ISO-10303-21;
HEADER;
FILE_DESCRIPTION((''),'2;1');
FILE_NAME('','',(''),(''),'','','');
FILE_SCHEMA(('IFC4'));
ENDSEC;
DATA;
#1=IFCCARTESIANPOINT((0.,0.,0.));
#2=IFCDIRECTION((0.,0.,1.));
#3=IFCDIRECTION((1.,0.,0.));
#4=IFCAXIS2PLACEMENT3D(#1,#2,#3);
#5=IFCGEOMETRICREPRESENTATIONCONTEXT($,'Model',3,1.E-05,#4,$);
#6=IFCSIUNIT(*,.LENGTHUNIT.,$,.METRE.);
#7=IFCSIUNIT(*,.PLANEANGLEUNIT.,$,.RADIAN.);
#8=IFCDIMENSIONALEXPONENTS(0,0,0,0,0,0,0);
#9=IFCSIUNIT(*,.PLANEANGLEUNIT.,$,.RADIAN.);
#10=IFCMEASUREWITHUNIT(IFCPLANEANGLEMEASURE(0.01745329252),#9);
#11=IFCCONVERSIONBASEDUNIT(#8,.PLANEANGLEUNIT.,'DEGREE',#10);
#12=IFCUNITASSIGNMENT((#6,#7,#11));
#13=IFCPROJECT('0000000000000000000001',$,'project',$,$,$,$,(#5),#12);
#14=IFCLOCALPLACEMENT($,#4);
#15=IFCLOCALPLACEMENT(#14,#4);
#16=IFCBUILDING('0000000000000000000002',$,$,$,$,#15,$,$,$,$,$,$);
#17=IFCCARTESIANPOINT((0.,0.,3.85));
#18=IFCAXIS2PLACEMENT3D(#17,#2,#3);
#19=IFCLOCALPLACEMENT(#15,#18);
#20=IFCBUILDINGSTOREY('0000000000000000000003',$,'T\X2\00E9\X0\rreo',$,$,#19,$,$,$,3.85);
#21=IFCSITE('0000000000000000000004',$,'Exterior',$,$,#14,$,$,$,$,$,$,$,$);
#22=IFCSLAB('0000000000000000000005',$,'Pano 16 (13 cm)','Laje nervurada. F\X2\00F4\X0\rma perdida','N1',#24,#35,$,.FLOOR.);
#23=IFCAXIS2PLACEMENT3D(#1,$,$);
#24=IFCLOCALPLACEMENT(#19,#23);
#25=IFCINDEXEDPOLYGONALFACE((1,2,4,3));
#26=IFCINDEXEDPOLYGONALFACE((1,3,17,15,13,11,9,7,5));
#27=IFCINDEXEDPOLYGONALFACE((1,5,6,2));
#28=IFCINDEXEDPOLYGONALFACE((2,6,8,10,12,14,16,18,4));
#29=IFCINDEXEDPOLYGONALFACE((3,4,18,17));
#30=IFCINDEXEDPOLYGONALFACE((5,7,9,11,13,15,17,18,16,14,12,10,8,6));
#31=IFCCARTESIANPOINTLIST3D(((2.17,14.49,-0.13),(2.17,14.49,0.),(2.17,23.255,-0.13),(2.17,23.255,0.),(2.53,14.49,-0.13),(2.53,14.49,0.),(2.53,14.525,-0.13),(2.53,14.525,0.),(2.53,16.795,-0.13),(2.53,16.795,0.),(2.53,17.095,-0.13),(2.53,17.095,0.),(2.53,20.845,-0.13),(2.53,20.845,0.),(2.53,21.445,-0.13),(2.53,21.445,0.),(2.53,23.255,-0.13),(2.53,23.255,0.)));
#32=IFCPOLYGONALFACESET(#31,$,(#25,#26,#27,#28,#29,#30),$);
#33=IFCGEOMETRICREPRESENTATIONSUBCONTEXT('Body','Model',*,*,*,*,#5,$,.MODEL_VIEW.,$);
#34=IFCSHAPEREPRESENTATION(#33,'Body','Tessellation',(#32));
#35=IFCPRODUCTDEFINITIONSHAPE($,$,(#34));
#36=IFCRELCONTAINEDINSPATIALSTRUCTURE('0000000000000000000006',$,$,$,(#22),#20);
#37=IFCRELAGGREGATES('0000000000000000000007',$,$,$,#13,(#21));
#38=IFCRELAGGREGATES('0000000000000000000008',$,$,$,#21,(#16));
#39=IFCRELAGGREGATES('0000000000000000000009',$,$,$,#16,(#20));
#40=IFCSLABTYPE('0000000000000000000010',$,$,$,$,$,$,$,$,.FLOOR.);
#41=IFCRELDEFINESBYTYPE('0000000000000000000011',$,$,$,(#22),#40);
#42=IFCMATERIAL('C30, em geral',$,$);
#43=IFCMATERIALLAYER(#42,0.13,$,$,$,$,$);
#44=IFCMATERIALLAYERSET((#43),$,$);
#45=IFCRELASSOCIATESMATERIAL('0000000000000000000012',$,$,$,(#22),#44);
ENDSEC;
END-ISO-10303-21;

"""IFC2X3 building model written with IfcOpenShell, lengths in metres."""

from ifc_helpers import new_model, entity, si_unit, converted_unit, frame, origin_with_axes, place, context, subcontext, project, spatial, polyline, outline, extrude, material, layer, layer_set, layer_usage, type_object, element, save


model = new_model("IFC2X3")

# Units and contexts
model_context = context("Model", 3, precision=1e-05, world=origin_with_axes())
body_context = subcontext(model_context, "Body", "Model", "MODEL_VIEW")
ifc_project = project(units=[si_unit("LENGTHUNIT", "METRE"), si_unit("PLANEANGLEUNIT", "RADIAN"), converted_unit("PLANEANGLEUNIT", "DEGREE", entity("IfcPlaneAngleMeasure", 0.01745329252), si_unit("PLANEANGLEUNIT", "RADIAN"), dimensions=[0, 0, 0, 0, 0, 0, 0])], contexts=[model_context])

# Site, building, storey
site_placement = place(None, origin_with_axes())
site = spatial("IfcSite", under=ifc_project, at=site_placement, Name="Exterior")
building_placement = place(site_placement, origin_with_axes())
building = spatial("IfcBuilding", under=site, at=building_placement)
storey_placement = place(building_placement, frame((0.0, 0.0, 3.85), z_axis=(0.0, 0.0, 1.0), x_axis=(1.0, 0.0, 0.0)))
storey = spatial("IfcBuildingStorey", under=building, at=storey_placement, Name="Térreo", Elevation=3.85)

# Shared definitions
ifc_material_1 = material(Name="C30, em geral")

# Shared definitions
slab_type = type_object("IfcSlabType", PredefinedType="FLOOR")

# Slab
ifc_layer_1 = layer(ifc_material_1, 0.13)
ifc_layer_set_1 = layer_set([ifc_layer_1])
ifc_layer_usage_1 = layer_usage(ifc_layer_set_1, "AXIS3", "POSITIVE", 0.0)
slab_1_placement = place(storey_placement, frame((0.0, 0.0, -0.13), z_axis=(0.0, 0.0, 1.0), x_axis=(1.0, 0.0, 0.0)))
element("IfcSlab", 1, at=slab_1_placement, inside=storey, type_object=slab_type, material=ifc_layer_usage_1, Name="Pano 16 (13 cm)", Description="Laje nervurada. Fôrma perdida", ObjectType="N1", PredefinedType="FLOOR", context=body_context, shape_type="SweptSolid", body=[
    extrude(outline(polyline([(2.53, 17.095), (2.53, 20.845), (2.53, 21.445), (2.53, 23.255), (2.17, 23.255), (2.17, 14.49), (2.53, 14.49), (2.53, 14.525), (2.53, 16.795), (2.53, 17.095)])), origin_with_axes(), (0.0, 0.0, 1.0), 0.13),
])

save(model, "model.ifc")
